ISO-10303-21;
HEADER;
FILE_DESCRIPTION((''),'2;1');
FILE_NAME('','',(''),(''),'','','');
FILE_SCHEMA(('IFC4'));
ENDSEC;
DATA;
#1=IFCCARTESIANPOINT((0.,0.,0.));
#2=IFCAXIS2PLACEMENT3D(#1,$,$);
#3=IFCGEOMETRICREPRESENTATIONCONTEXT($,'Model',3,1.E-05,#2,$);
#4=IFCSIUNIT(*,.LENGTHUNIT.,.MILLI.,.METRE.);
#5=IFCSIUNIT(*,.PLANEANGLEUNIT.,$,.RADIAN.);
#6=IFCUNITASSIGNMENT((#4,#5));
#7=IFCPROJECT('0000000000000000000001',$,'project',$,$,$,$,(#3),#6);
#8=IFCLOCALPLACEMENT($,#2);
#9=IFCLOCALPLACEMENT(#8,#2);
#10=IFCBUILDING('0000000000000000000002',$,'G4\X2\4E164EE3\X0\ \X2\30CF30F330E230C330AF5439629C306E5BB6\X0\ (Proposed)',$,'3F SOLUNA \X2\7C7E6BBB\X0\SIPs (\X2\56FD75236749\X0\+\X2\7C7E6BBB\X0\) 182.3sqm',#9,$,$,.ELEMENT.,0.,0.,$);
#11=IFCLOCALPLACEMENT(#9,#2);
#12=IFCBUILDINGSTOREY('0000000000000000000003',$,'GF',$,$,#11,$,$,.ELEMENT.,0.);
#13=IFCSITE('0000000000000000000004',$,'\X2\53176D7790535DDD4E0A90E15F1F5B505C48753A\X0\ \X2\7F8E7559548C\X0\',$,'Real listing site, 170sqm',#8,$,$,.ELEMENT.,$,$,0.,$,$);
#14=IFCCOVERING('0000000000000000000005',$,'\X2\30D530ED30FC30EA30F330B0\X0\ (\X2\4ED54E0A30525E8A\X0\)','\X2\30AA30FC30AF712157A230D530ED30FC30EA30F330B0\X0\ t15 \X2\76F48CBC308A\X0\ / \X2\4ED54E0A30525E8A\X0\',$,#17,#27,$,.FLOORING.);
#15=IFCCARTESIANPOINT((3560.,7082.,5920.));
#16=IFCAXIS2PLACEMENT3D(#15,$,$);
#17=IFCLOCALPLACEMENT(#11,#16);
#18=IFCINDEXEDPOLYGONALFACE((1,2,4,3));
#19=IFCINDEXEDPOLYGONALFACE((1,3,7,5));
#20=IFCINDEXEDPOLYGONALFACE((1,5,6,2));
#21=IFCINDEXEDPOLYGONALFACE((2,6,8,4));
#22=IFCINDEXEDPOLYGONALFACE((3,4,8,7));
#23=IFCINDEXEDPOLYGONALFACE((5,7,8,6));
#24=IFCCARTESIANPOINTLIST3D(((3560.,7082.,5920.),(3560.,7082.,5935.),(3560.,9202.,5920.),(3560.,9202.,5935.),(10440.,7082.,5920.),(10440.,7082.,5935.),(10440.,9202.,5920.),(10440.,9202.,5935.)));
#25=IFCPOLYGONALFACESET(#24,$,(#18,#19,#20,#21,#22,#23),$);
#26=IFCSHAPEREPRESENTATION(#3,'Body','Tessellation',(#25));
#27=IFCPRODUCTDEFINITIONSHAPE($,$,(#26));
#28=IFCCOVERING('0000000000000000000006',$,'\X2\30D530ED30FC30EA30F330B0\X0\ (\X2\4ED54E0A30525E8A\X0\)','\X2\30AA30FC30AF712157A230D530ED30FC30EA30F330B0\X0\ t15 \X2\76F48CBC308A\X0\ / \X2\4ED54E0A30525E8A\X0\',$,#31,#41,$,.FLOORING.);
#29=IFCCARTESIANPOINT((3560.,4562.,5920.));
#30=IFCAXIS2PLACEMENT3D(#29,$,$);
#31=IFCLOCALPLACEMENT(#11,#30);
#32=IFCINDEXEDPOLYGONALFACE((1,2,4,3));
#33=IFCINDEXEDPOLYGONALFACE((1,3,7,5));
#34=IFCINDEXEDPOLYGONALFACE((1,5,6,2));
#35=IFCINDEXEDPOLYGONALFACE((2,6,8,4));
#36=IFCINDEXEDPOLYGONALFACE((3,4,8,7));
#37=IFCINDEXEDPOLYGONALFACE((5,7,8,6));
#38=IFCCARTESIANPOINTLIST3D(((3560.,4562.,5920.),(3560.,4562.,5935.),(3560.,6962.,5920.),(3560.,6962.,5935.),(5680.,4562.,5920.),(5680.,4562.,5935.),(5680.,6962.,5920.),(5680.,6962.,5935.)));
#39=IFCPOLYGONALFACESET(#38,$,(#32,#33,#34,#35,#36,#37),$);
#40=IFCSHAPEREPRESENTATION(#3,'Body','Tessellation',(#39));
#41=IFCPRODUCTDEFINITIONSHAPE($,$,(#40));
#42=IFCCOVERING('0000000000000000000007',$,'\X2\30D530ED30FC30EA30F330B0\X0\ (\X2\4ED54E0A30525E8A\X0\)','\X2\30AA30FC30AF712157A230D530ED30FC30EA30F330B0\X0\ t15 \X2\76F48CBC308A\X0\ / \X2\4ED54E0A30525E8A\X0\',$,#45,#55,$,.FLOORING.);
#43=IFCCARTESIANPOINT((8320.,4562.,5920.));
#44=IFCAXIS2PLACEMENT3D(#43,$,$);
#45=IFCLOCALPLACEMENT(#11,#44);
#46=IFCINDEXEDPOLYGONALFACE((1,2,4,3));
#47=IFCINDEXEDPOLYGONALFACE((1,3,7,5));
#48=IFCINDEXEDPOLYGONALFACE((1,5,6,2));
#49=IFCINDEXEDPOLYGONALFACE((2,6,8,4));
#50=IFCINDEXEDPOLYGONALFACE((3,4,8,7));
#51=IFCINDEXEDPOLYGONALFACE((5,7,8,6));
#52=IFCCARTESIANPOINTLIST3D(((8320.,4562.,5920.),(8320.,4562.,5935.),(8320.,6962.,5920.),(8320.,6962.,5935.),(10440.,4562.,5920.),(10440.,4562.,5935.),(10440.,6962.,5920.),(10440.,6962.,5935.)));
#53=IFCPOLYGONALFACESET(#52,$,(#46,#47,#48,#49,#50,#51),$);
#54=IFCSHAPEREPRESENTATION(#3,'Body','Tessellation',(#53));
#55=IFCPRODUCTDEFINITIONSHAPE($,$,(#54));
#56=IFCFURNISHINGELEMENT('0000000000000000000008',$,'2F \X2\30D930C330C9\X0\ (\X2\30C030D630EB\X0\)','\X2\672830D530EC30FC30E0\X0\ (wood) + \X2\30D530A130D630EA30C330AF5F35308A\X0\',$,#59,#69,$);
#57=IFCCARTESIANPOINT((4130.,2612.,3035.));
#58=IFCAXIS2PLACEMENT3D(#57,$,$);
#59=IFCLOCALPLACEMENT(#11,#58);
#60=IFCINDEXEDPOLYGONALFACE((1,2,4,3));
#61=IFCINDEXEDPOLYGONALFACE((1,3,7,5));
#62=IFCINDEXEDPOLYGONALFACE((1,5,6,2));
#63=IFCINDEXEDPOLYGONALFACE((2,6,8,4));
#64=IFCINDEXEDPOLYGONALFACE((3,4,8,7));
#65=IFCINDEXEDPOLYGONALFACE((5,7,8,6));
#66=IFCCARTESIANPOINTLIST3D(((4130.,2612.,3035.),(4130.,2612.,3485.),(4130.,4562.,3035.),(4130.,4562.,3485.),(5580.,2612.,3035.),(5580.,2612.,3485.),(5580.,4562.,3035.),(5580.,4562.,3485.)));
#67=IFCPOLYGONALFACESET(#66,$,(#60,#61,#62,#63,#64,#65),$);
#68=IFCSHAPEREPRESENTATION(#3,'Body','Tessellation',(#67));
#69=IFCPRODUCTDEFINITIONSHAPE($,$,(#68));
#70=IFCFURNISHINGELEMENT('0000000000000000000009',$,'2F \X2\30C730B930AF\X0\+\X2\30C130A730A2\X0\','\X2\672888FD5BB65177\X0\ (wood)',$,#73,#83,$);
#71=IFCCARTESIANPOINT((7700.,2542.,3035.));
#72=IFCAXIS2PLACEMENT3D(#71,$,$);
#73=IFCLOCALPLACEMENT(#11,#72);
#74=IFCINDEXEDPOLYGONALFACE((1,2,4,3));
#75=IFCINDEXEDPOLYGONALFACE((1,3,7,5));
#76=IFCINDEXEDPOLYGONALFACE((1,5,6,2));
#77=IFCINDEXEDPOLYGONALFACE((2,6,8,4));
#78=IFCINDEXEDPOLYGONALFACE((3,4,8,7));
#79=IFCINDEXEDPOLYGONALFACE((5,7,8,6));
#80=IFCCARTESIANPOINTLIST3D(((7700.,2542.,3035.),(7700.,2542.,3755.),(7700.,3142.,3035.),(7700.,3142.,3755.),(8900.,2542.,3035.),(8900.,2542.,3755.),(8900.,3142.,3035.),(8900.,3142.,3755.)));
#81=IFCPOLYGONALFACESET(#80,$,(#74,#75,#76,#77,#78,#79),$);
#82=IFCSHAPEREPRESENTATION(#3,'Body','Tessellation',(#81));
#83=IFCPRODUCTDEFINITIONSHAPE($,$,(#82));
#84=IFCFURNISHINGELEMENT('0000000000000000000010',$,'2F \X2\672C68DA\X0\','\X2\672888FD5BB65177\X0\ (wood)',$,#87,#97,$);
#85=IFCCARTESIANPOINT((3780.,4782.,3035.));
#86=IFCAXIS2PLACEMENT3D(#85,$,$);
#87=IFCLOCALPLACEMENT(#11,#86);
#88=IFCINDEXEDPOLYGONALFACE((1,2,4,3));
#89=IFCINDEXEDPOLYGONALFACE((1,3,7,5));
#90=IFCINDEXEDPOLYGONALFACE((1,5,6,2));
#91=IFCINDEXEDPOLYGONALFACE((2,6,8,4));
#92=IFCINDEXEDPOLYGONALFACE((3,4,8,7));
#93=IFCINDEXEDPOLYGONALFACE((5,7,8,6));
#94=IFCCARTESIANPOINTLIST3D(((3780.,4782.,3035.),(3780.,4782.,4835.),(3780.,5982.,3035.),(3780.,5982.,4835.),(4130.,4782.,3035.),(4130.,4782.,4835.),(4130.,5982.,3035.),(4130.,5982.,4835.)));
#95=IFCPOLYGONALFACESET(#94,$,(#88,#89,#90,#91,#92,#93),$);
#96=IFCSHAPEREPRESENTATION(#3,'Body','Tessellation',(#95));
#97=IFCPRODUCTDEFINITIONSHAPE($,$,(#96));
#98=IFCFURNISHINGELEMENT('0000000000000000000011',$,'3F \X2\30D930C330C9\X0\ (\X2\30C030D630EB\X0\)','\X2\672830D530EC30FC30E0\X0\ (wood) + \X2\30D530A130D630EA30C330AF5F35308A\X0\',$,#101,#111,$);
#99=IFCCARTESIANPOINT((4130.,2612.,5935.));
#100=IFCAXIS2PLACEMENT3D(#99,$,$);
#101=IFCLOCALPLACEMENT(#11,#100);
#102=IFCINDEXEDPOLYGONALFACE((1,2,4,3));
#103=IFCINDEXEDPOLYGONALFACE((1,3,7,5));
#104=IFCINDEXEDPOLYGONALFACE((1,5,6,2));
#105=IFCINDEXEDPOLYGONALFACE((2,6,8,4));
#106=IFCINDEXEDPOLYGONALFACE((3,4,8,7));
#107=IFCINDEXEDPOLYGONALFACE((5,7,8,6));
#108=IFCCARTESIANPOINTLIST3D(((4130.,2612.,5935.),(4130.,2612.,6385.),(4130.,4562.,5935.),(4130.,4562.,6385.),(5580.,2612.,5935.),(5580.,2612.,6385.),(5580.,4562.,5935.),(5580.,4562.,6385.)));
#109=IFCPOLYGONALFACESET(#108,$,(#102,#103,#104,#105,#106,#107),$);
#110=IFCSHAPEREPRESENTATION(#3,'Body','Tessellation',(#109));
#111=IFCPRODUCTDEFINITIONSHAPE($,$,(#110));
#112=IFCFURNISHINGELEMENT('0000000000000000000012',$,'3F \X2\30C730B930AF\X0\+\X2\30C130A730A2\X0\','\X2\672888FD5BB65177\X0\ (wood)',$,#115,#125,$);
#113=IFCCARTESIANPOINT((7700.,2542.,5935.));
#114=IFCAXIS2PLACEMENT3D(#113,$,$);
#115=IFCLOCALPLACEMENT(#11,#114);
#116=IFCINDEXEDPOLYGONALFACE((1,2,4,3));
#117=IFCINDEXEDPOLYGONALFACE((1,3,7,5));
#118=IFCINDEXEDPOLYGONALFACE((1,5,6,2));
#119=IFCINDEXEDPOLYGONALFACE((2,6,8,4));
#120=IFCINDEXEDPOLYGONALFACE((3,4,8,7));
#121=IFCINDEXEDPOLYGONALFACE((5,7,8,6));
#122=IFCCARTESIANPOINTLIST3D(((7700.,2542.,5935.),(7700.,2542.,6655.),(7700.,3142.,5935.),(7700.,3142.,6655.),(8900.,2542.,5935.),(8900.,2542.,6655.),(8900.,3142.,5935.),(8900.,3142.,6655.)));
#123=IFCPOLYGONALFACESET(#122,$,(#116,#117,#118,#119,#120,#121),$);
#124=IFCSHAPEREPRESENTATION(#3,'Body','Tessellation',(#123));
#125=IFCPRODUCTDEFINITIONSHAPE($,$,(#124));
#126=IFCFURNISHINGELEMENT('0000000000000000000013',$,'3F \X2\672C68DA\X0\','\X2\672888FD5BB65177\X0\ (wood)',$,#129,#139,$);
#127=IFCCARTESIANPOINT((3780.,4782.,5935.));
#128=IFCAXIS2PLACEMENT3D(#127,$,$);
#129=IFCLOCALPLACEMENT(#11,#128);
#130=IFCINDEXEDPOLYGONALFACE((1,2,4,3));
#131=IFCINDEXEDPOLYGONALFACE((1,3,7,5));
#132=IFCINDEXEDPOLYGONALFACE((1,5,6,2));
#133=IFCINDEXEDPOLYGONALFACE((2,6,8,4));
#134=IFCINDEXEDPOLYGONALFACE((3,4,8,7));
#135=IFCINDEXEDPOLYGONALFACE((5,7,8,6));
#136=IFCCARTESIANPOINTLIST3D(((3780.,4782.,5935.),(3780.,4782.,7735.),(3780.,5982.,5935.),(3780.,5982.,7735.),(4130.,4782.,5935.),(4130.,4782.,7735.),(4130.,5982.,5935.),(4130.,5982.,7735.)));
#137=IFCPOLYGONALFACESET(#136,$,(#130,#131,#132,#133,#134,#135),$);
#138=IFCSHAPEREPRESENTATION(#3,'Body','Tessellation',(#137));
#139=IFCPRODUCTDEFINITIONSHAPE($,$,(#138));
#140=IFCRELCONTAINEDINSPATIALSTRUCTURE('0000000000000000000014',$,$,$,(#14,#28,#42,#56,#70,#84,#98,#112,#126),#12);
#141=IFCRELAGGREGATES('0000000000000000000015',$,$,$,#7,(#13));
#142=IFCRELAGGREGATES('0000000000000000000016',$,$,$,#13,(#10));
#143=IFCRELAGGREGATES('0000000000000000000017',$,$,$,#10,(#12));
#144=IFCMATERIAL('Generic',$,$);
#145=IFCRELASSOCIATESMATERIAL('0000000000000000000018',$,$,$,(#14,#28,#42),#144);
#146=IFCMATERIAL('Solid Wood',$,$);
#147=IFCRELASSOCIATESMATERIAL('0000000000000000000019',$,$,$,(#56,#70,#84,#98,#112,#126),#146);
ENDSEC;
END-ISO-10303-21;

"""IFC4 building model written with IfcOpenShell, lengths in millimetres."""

from ifc_helpers import new_model, si_unit, frame, frame_2d, origin, place, context, project, spatial, rectangle, extrude, material, element, save


model = new_model("IFC4")

# Units and contexts
model_context = context("Model", 3, precision=1e-05, world=origin())
ifc_project = project(units=[si_unit("LENGTHUNIT", "METRE", prefix="MILLI"), si_unit("PLANEANGLEUNIT", "RADIAN")], contexts=[model_context])

# Site, building, storey
site_placement = place(None, origin())
site = spatial("IfcSite", under=ifc_project, at=site_placement, Name="北海道川上郡弟子屈町 美留和", ObjectType="Real listing site, 170sqm", CompositionType="ELEMENT", RefElevation=0.0)
building_placement = place(site_placement, origin())
building = spatial("IfcBuilding", under=site, at=building_placement, Name="G4世代 ハンモック吹抜の家 (Proposed)", ObjectType="3F SOLUNA 籾殻SIPs (国産杉+籾殻) 182.3sqm", CompositionType="ELEMENT", ElevationOfRefHeight=0.0, ElevationOfTerrain=0.0)
storey_placement = place(building_placement, origin())
storey = spatial("IfcBuildingStorey", under=building, at=storey_placement, Name="GF", CompositionType="ELEMENT", Elevation=0.0)

# Shared definitions
ifc_material_1 = material(Name="Solid Wood")

# Shared definitions
ifc_material_2 = material(Name="Generic")

# Coverings
covering_1_placement = place(storey_placement, frame((3560.0, 7082.0, 5920.0)))
element("IfcCovering", 1, at=covering_1_placement, inside=storey, material=ifc_material_2, Name="フローリング (仕上げ床)", Description="オーク無垢フローリング t15 直貼り / 仕上げ床", PredefinedType="FLOORING", context=model_context, shape_type="SweptSolid", body=[
    extrude(rectangle(XDim=6880.0, YDim=2120.0, at=frame_2d((3440.0, 1060.0))), frame((3560.0, 7082.0, 5920.0)), (0.0, 0.0, 1.0), 15.0),
])
covering_2_placement = place(storey_placement, frame((3560.0, 4562.0, 5920.0)))
element("IfcCovering", 2, at=covering_2_placement, inside=storey, material=ifc_material_2, Name="フローリング (仕上げ床)", Description="オーク無垢フローリング t15 直貼り / 仕上げ床", PredefinedType="FLOORING", context=model_context, shape_type="SweptSolid", body=[
    extrude(rectangle(XDim=2120.0, YDim=2400.0, at=frame_2d((1060.0, 1200.0))), frame((3560.0, 4562.0, 5920.0)), (0.0, 0.0, 1.0), 15.0),
])
covering_3_placement = place(storey_placement, frame((8320.0, 4562.0, 5920.0)))
element("IfcCovering", 3, at=covering_3_placement, inside=storey, material=ifc_material_2, Name="フローリング (仕上げ床)", Description="オーク無垢フローリング t15 直貼り / 仕上げ床", PredefinedType="FLOORING", context=model_context, shape_type="SweptSolid", body=[
    extrude(rectangle(XDim=2120.0, YDim=2400.0, at=frame_2d((1060.0, 1200.0))), frame((8320.0, 4562.0, 5920.0)), (0.0, 0.0, 1.0), 15.0),
])

# Furnishing elements
furnishing_1_placement = place(storey_placement, frame((4130.0, 2612.0, 3035.0)))
element("IfcFurnishingElement", 4, at=furnishing_1_placement, inside=storey, material=ifc_material_1, Name="2F ベッド (ダブル)", Description="木フレーム (wood) + ファブリック張り", context=model_context, shape_type="SweptSolid", body=[
    extrude(rectangle(XDim=1450.0, YDim=1950.0, at=frame_2d((725.0, 975.0))), frame((4130.0, 2612.0, 3035.0)), (0.0, 0.0, 1.0), 450.0),
])
furnishing_2_placement = place(storey_placement, frame((7700.0, 2542.0, 3035.0)))
element("IfcFurnishingElement", 5, at=furnishing_2_placement, inside=storey, material=ifc_material_1, Name="2F デスク+チェア", Description="木製家具 (wood)", context=model_context, shape_type="SweptSolid", body=[
    extrude(rectangle(XDim=1200.0, YDim=600.0, at=frame_2d((600.0, 300.0))), frame((7700.0, 2542.0, 3035.0)), (0.0, 0.0, 1.0), 720.0),
])
furnishing_3_placement = place(storey_placement, frame((3780.0, 4782.0, 3035.0)))
element("IfcFurnishingElement", 6, at=furnishing_3_placement, inside=storey, material=ifc_material_1, Name="2F 本棚", Description="木製家具 (wood)", context=model_context, shape_type="SweptSolid", body=[
    extrude(rectangle(XDim=350.0, YDim=1200.0, at=frame_2d((175.0, 600.0))), frame((3780.0, 4782.0, 3035.0)), (0.0, 0.0, 1.0), 1800.0),
])
furnishing_4_placement = place(storey_placement, frame((4130.0, 2612.0, 5935.0)))
element("IfcFurnishingElement", 7, at=furnishing_4_placement, inside=storey, material=ifc_material_1, Name="3F ベッド (ダブル)", Description="木フレーム (wood) + ファブリック張り", context=model_context, shape_type="SweptSolid", body=[
    extrude(rectangle(XDim=1450.0, YDim=1950.0, at=frame_2d((725.0, 975.0))), frame((4130.0, 2612.0, 5935.0)), (0.0, 0.0, 1.0), 450.0),
])
furnishing_5_placement = place(storey_placement, frame((7700.0, 2542.0, 5935.0)))
element("IfcFurnishingElement", 8, at=furnishing_5_placement, inside=storey, material=ifc_material_1, Name="3F デスク+チェア", Description="木製家具 (wood)", context=model_context, shape_type="SweptSolid", body=[
    extrude(rectangle(XDim=1200.0, YDim=600.0, at=frame_2d((600.0, 300.0))), frame((7700.0, 2542.0, 5935.0)), (0.0, 0.0, 1.0), 720.0),
])
furnishing_6_placement = place(storey_placement, frame((3780.0, 4782.0, 5935.0)))
element("IfcFurnishingElement", 9, at=furnishing_6_placement, inside=storey, material=ifc_material_1, Name="3F 本棚", Description="木製家具 (wood)", context=model_context, shape_type="SweptSolid", body=[
    extrude(rectangle(XDim=350.0, YDim=1200.0, at=frame_2d((175.0, 600.0))), frame((3780.0, 4782.0, 5935.0)), (0.0, 0.0, 1.0), 1800.0),
])

save(model, "model.ifc")
